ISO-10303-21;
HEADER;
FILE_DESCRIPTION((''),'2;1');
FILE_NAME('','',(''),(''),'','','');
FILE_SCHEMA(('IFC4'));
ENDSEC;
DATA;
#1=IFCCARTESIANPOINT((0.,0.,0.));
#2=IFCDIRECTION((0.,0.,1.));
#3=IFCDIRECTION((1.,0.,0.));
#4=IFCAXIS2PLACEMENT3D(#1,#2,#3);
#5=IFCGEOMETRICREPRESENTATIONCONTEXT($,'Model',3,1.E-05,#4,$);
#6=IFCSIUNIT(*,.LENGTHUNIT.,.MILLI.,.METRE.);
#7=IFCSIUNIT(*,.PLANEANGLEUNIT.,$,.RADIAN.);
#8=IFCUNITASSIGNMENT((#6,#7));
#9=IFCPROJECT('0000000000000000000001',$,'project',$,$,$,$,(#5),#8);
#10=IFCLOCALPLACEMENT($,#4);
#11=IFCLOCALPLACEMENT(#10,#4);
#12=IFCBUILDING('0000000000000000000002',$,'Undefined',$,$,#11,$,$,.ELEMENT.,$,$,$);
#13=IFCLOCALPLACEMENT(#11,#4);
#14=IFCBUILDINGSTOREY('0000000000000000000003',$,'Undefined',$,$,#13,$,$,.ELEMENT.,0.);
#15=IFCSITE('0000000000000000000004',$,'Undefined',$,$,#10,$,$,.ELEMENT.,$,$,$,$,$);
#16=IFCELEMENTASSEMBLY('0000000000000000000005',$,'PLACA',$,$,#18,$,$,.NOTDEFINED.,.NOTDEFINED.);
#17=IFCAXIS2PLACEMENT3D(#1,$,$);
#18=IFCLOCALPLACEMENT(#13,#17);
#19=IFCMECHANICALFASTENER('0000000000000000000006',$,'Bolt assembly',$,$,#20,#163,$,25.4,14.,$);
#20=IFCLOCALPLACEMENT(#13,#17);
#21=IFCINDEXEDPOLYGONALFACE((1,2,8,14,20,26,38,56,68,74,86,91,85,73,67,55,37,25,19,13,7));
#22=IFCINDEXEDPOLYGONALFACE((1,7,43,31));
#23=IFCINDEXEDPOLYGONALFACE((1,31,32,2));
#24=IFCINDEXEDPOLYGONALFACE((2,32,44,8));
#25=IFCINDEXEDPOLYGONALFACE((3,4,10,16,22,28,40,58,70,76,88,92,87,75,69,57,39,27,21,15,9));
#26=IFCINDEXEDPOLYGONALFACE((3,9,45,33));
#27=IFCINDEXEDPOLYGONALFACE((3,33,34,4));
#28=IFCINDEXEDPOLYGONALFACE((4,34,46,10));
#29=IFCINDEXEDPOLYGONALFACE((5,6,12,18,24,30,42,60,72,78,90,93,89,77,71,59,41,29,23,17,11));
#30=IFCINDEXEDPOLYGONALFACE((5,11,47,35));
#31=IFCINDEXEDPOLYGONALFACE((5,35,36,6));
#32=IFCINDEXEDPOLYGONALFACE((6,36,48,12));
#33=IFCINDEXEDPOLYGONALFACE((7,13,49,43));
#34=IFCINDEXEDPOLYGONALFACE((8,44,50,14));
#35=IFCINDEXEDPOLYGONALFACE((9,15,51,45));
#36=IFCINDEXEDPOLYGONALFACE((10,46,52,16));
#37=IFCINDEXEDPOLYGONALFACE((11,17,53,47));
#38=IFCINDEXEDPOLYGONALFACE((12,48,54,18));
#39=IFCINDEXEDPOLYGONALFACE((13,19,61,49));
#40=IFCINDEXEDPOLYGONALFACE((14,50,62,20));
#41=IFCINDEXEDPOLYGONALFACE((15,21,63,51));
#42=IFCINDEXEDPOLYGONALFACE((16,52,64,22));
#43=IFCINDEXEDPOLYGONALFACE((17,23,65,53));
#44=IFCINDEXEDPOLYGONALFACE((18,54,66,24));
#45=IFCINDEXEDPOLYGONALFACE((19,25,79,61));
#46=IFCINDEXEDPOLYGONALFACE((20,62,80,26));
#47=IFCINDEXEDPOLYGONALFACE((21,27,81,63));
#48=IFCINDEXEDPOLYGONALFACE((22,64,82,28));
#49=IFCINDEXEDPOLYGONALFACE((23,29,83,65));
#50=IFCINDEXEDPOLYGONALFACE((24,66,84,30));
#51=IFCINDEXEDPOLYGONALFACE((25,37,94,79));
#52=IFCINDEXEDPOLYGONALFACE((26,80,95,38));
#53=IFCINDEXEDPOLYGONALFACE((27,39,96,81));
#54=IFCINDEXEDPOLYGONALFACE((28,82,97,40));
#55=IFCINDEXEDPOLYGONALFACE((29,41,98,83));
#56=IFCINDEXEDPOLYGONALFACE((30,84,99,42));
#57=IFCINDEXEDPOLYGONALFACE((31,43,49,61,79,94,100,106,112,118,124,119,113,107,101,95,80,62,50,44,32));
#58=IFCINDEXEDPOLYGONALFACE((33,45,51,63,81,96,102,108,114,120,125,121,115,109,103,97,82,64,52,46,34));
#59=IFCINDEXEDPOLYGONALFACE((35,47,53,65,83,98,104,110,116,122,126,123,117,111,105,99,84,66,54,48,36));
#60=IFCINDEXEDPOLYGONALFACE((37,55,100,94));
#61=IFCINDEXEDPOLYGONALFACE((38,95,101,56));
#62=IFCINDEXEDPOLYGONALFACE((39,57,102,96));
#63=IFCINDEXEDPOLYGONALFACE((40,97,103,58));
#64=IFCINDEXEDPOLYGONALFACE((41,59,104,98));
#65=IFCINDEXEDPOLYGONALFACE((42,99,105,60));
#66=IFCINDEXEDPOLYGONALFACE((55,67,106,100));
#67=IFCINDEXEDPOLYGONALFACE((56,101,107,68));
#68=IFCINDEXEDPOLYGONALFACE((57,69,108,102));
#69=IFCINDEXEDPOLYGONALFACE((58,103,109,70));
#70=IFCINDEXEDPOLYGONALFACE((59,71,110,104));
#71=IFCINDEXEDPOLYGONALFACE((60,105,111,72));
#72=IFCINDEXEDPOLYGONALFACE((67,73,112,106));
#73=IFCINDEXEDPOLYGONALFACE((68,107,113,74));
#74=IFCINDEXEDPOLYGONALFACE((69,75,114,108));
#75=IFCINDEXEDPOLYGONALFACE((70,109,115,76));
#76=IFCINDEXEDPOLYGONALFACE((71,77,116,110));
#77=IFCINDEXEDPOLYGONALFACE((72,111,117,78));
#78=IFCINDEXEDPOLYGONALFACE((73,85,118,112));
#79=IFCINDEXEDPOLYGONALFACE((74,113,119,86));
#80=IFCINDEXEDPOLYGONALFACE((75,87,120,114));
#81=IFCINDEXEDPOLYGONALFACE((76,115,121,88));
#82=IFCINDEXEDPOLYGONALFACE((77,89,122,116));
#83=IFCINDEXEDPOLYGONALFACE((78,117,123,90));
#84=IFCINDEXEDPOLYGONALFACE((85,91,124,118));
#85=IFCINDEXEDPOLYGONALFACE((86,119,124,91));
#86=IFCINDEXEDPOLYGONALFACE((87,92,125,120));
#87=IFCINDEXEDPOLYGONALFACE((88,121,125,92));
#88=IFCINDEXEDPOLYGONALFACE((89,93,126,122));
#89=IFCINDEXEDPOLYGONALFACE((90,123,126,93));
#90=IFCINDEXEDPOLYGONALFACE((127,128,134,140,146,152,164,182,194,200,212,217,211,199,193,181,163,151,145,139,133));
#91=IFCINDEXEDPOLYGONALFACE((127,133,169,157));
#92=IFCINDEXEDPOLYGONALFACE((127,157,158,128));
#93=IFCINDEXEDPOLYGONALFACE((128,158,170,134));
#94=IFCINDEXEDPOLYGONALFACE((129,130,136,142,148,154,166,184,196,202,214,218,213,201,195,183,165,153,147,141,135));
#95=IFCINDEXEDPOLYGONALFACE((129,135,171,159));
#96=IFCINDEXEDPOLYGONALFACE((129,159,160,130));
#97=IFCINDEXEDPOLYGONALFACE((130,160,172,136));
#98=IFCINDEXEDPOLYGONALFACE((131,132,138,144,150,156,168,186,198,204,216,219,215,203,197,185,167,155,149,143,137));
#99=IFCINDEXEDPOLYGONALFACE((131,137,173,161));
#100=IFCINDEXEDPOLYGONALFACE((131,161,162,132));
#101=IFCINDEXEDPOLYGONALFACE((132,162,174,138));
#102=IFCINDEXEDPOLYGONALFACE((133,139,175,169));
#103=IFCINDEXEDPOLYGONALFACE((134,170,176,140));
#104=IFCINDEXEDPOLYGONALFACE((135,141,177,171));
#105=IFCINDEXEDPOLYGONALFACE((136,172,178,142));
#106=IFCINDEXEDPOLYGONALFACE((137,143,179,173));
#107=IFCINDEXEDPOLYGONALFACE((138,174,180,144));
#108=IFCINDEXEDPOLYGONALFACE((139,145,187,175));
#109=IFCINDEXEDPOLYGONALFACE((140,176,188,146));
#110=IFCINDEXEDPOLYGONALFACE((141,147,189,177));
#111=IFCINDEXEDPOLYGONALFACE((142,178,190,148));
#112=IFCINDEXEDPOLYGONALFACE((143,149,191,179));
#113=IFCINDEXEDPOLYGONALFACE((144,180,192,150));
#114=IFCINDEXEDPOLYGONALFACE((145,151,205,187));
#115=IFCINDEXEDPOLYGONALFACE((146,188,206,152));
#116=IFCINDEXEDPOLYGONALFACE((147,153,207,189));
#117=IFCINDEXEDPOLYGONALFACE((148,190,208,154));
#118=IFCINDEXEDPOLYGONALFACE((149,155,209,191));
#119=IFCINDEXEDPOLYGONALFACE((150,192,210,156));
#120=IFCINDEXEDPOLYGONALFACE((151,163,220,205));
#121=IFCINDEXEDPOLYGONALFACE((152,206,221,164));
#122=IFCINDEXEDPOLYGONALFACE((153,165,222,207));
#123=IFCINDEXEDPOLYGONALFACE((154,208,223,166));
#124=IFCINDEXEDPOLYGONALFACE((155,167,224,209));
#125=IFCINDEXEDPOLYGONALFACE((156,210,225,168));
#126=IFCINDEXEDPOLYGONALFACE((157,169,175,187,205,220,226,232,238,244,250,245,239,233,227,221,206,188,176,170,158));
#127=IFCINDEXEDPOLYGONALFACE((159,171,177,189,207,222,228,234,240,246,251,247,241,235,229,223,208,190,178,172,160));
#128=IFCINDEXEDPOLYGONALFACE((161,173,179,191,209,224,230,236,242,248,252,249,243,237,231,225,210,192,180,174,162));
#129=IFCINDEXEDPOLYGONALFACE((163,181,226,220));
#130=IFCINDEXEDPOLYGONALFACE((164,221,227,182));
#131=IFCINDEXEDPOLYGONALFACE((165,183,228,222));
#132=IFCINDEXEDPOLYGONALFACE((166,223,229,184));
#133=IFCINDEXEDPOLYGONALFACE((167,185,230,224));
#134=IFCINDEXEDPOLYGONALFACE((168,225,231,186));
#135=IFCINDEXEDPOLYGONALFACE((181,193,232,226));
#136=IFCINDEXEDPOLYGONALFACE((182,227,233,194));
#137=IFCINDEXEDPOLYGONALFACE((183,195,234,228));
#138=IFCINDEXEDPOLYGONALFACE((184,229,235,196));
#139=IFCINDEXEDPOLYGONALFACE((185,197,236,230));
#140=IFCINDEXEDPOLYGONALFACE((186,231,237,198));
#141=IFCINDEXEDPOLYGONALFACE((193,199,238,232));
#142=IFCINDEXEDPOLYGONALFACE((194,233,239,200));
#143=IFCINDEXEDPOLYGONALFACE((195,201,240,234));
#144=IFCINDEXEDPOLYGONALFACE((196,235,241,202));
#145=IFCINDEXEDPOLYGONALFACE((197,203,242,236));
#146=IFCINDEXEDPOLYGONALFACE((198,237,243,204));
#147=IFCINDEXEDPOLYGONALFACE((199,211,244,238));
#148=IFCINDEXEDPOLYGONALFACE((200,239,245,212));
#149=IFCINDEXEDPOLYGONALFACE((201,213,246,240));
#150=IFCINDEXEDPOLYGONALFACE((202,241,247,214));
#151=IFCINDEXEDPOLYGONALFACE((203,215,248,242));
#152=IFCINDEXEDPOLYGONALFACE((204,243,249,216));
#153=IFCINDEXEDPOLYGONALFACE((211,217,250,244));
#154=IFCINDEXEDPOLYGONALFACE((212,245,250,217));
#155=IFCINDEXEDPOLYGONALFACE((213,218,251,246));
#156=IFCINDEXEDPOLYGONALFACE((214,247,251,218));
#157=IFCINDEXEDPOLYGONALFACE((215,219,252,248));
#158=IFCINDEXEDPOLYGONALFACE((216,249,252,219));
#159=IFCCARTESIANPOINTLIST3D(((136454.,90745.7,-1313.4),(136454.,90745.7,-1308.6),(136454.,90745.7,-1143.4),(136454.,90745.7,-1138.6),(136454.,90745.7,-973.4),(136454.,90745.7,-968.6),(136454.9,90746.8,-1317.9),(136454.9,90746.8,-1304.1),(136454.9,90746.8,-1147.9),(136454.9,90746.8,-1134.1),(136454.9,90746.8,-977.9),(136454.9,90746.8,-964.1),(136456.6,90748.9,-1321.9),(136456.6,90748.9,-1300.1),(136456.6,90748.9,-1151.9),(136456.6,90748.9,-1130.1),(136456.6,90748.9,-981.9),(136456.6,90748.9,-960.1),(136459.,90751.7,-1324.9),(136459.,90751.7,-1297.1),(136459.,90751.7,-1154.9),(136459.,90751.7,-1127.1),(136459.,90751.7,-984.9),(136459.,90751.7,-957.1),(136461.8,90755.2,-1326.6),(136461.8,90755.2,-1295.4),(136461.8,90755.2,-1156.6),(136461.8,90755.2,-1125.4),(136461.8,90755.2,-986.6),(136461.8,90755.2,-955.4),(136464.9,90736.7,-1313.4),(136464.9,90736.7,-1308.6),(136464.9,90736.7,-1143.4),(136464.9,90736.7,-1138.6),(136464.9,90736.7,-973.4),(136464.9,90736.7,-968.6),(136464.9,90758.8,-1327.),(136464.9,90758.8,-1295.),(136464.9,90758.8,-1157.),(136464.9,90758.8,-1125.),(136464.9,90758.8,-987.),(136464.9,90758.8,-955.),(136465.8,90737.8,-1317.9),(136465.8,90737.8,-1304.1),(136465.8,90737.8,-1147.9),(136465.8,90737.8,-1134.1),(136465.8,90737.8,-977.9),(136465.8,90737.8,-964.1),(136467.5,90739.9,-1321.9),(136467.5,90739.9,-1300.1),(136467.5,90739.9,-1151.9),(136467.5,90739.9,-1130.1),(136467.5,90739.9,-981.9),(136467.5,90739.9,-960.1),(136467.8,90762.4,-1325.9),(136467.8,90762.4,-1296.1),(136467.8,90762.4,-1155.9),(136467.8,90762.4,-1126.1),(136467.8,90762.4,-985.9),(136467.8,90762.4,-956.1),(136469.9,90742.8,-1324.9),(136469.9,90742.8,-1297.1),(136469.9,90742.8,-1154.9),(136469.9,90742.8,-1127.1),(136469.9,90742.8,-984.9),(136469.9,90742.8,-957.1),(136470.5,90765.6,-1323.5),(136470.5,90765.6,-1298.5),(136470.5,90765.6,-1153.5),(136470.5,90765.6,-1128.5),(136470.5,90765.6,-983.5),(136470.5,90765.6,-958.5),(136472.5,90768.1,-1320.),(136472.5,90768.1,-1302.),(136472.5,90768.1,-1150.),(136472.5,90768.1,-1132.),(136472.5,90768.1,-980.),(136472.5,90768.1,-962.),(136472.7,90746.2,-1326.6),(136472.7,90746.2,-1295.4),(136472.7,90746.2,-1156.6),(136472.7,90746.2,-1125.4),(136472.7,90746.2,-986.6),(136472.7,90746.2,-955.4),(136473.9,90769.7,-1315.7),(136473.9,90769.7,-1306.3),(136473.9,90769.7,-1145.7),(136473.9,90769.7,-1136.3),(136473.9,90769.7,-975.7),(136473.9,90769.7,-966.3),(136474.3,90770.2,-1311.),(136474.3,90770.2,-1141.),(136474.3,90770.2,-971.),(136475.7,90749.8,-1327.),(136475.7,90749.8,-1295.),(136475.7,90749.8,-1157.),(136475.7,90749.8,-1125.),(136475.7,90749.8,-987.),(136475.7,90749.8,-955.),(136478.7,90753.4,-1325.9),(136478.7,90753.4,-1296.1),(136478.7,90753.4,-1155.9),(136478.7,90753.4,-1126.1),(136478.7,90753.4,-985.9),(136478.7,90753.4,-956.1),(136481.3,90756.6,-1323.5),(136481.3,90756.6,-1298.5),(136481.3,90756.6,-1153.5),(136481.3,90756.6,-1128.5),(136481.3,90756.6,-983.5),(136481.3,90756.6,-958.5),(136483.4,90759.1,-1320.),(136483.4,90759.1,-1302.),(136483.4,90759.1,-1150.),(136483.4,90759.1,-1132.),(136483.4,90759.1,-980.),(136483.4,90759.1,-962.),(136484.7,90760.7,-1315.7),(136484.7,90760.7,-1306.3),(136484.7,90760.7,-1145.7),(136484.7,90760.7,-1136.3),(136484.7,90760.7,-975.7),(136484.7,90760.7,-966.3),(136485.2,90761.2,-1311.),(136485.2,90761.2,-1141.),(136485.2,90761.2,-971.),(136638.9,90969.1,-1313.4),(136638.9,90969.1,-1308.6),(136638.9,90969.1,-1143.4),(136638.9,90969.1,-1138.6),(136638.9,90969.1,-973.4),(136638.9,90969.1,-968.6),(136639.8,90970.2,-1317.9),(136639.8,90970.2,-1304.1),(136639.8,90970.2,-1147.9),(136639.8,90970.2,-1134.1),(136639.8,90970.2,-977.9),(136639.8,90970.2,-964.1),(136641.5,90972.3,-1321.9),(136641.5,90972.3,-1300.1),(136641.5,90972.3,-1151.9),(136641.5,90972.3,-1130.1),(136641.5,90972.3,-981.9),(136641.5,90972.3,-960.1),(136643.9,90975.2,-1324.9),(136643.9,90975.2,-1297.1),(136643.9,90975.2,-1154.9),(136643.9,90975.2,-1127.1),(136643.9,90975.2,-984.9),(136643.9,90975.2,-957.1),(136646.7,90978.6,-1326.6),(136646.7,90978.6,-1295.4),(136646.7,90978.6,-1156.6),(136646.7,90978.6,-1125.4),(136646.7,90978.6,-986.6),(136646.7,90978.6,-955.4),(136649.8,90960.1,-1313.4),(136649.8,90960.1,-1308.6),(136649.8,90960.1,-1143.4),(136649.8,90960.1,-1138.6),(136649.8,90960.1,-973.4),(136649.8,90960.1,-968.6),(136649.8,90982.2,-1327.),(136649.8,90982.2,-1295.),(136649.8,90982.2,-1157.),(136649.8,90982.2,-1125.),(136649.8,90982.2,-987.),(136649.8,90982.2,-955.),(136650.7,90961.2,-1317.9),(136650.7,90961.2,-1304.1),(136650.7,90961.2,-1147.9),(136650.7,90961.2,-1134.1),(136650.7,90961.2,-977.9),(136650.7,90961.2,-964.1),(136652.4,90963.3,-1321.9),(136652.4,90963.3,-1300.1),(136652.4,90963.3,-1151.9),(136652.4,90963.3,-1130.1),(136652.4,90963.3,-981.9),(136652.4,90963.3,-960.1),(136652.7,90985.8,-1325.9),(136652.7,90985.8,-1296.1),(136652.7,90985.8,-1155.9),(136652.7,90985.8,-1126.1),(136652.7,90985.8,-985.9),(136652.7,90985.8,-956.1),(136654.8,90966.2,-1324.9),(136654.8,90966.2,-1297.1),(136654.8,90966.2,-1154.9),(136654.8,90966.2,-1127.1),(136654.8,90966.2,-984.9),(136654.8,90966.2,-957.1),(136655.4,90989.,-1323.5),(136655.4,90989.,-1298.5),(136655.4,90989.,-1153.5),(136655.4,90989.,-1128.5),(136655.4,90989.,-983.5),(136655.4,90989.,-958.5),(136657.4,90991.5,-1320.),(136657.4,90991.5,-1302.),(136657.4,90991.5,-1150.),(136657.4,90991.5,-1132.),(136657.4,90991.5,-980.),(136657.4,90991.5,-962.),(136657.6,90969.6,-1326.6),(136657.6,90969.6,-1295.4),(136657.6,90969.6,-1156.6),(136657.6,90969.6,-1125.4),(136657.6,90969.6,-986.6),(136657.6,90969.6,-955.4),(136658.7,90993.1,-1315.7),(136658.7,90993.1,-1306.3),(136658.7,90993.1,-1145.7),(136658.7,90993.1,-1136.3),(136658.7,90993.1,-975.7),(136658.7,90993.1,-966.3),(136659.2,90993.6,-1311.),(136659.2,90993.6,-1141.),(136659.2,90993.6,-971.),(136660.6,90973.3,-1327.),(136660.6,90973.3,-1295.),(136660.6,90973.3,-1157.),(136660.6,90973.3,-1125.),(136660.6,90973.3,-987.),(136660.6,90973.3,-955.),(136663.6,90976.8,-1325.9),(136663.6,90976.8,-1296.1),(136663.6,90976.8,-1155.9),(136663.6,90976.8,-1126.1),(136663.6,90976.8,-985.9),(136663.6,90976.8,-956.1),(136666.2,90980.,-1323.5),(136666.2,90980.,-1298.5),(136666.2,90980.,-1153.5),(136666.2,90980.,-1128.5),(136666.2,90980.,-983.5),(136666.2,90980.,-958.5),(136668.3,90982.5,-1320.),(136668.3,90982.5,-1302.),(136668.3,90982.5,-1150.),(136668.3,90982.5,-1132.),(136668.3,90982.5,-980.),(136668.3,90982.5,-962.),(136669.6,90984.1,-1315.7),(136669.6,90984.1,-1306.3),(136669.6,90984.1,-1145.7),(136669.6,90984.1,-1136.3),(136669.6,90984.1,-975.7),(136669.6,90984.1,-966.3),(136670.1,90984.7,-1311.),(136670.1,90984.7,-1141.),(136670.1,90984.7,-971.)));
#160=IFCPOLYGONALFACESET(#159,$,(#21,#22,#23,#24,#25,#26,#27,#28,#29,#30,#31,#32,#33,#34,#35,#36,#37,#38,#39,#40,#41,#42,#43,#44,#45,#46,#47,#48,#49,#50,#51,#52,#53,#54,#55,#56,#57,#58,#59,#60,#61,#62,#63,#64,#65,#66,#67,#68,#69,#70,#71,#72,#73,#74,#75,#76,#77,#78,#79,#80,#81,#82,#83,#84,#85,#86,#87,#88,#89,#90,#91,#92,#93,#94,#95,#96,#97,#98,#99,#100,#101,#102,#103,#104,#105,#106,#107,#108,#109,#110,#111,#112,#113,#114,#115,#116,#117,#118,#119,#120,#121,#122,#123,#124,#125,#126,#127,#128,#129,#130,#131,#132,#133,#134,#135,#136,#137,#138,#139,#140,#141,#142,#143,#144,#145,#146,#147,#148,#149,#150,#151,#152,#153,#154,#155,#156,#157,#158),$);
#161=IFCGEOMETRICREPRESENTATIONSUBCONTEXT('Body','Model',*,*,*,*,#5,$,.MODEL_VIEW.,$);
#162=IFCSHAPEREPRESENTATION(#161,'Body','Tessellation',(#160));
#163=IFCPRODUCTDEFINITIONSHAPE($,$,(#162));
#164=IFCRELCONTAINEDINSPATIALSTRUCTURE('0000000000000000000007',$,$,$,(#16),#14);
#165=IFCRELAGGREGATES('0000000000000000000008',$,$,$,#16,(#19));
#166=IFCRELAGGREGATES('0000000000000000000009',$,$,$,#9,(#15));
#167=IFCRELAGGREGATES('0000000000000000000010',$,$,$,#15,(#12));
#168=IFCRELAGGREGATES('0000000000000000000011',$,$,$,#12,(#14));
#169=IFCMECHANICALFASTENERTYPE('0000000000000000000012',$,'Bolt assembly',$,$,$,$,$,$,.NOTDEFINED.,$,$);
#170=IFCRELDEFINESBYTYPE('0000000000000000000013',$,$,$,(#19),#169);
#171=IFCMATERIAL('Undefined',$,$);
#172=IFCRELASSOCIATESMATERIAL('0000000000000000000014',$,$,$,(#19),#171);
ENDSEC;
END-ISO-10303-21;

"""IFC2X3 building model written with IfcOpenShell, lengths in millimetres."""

from ifc_helpers import new_model, si_unit, frame, origin_with_axes, origin_2d_with_axis, place, context, subcontext, project, spatial, circle, extrude, source, transform, mapped, material, type_object, element, aggregate, save


model = new_model("IFC2X3")

# Units and contexts
model_context = context("Model", 3, precision=1e-05, world=origin_with_axes())
body_context = subcontext(model_context, "Body", "Model", "MODEL_VIEW")
ifc_project = project(units=[si_unit("LENGTHUNIT", "METRE", prefix="MILLI"), si_unit("PLANEANGLEUNIT", "RADIAN")], contexts=[model_context])

# Site, building, storey
site_placement = place(None, origin_with_axes())
site = spatial("IfcSite", under=ifc_project, at=site_placement, Name="Undefined", CompositionType="ELEMENT")
building_placement = place(site_placement, origin_with_axes())
building = spatial("IfcBuilding", under=site, at=building_placement, Name="Undefined", CompositionType="ELEMENT")
storey_placement = place(building_placement, origin_with_axes())
storey = spatial("IfcBuildingStorey", under=building, at=storey_placement, Name="Undefined", CompositionType="ELEMENT", Elevation=0.0)

# Element assembly
assembly_1_placement = place(storey_placement, origin_with_axes())
assembly_1 = element("IfcElementAssembly", 1, at=assembly_1_placement, inside=storey, Name="PLACA", AssemblyPlace="NOTDEFINED", PredefinedType="NOTDEFINED")

# Shared definitions
ifc_material_1 = material(Name="Undefined")
mechanical_fastener_type = type_object("IfcMechanicalFastenerType", Name="Bolt assembly")

# Mechanical fastener
shared_shape_1 = source(origin_with_axes(), body_context, "Body", "SweptSolid", [
    extrude(circle(Radius=16.0, at=origin_2d_with_axis()), frame((0.0, 0.0, 0.0), z_axis=(0.0, 1.0, 0.0), x_axis=(1.0, 0.0, 0.0)), (0.0, 0.0, 1.0), 14.1),
])
mechanical_fastener_1_placement = place(assembly_1_placement, frame((136475.0, 90748.9, -1141.0), z_axis=(0.000001, 0.000001, 1.0), x_axis=(0.63756, 0.770401, -0.000002)))
mechanical_fastener_1 = element("IfcMechanicalFastener", 2, at=mechanical_fastener_1_placement, type_object=mechanical_fastener_type, material=ifc_material_1, Name="Bolt assembly", NominalDiameter=25.4, NominalLength=14.0, context=body_context, shape_type="MappedRepresentation", body=[
    mapped(shared_shape_1, transform((0.0, 0.0, -170.0))),
    mapped(shared_shape_1, transform((290.0, 0.0, -170.0))),
    mapped(shared_shape_1, transform((0.0, 0.0, 0.0))),
    mapped(shared_shape_1, transform((290.0, 0.0, 0.0))),
    mapped(shared_shape_1, transform((0.0, 0.0, 170.0))),
    mapped(shared_shape_1, transform((290.0, 0.0, 170.0))),
])
aggregate(assembly_1, [mechanical_fastener_1])

save(model, "model.ifc")
